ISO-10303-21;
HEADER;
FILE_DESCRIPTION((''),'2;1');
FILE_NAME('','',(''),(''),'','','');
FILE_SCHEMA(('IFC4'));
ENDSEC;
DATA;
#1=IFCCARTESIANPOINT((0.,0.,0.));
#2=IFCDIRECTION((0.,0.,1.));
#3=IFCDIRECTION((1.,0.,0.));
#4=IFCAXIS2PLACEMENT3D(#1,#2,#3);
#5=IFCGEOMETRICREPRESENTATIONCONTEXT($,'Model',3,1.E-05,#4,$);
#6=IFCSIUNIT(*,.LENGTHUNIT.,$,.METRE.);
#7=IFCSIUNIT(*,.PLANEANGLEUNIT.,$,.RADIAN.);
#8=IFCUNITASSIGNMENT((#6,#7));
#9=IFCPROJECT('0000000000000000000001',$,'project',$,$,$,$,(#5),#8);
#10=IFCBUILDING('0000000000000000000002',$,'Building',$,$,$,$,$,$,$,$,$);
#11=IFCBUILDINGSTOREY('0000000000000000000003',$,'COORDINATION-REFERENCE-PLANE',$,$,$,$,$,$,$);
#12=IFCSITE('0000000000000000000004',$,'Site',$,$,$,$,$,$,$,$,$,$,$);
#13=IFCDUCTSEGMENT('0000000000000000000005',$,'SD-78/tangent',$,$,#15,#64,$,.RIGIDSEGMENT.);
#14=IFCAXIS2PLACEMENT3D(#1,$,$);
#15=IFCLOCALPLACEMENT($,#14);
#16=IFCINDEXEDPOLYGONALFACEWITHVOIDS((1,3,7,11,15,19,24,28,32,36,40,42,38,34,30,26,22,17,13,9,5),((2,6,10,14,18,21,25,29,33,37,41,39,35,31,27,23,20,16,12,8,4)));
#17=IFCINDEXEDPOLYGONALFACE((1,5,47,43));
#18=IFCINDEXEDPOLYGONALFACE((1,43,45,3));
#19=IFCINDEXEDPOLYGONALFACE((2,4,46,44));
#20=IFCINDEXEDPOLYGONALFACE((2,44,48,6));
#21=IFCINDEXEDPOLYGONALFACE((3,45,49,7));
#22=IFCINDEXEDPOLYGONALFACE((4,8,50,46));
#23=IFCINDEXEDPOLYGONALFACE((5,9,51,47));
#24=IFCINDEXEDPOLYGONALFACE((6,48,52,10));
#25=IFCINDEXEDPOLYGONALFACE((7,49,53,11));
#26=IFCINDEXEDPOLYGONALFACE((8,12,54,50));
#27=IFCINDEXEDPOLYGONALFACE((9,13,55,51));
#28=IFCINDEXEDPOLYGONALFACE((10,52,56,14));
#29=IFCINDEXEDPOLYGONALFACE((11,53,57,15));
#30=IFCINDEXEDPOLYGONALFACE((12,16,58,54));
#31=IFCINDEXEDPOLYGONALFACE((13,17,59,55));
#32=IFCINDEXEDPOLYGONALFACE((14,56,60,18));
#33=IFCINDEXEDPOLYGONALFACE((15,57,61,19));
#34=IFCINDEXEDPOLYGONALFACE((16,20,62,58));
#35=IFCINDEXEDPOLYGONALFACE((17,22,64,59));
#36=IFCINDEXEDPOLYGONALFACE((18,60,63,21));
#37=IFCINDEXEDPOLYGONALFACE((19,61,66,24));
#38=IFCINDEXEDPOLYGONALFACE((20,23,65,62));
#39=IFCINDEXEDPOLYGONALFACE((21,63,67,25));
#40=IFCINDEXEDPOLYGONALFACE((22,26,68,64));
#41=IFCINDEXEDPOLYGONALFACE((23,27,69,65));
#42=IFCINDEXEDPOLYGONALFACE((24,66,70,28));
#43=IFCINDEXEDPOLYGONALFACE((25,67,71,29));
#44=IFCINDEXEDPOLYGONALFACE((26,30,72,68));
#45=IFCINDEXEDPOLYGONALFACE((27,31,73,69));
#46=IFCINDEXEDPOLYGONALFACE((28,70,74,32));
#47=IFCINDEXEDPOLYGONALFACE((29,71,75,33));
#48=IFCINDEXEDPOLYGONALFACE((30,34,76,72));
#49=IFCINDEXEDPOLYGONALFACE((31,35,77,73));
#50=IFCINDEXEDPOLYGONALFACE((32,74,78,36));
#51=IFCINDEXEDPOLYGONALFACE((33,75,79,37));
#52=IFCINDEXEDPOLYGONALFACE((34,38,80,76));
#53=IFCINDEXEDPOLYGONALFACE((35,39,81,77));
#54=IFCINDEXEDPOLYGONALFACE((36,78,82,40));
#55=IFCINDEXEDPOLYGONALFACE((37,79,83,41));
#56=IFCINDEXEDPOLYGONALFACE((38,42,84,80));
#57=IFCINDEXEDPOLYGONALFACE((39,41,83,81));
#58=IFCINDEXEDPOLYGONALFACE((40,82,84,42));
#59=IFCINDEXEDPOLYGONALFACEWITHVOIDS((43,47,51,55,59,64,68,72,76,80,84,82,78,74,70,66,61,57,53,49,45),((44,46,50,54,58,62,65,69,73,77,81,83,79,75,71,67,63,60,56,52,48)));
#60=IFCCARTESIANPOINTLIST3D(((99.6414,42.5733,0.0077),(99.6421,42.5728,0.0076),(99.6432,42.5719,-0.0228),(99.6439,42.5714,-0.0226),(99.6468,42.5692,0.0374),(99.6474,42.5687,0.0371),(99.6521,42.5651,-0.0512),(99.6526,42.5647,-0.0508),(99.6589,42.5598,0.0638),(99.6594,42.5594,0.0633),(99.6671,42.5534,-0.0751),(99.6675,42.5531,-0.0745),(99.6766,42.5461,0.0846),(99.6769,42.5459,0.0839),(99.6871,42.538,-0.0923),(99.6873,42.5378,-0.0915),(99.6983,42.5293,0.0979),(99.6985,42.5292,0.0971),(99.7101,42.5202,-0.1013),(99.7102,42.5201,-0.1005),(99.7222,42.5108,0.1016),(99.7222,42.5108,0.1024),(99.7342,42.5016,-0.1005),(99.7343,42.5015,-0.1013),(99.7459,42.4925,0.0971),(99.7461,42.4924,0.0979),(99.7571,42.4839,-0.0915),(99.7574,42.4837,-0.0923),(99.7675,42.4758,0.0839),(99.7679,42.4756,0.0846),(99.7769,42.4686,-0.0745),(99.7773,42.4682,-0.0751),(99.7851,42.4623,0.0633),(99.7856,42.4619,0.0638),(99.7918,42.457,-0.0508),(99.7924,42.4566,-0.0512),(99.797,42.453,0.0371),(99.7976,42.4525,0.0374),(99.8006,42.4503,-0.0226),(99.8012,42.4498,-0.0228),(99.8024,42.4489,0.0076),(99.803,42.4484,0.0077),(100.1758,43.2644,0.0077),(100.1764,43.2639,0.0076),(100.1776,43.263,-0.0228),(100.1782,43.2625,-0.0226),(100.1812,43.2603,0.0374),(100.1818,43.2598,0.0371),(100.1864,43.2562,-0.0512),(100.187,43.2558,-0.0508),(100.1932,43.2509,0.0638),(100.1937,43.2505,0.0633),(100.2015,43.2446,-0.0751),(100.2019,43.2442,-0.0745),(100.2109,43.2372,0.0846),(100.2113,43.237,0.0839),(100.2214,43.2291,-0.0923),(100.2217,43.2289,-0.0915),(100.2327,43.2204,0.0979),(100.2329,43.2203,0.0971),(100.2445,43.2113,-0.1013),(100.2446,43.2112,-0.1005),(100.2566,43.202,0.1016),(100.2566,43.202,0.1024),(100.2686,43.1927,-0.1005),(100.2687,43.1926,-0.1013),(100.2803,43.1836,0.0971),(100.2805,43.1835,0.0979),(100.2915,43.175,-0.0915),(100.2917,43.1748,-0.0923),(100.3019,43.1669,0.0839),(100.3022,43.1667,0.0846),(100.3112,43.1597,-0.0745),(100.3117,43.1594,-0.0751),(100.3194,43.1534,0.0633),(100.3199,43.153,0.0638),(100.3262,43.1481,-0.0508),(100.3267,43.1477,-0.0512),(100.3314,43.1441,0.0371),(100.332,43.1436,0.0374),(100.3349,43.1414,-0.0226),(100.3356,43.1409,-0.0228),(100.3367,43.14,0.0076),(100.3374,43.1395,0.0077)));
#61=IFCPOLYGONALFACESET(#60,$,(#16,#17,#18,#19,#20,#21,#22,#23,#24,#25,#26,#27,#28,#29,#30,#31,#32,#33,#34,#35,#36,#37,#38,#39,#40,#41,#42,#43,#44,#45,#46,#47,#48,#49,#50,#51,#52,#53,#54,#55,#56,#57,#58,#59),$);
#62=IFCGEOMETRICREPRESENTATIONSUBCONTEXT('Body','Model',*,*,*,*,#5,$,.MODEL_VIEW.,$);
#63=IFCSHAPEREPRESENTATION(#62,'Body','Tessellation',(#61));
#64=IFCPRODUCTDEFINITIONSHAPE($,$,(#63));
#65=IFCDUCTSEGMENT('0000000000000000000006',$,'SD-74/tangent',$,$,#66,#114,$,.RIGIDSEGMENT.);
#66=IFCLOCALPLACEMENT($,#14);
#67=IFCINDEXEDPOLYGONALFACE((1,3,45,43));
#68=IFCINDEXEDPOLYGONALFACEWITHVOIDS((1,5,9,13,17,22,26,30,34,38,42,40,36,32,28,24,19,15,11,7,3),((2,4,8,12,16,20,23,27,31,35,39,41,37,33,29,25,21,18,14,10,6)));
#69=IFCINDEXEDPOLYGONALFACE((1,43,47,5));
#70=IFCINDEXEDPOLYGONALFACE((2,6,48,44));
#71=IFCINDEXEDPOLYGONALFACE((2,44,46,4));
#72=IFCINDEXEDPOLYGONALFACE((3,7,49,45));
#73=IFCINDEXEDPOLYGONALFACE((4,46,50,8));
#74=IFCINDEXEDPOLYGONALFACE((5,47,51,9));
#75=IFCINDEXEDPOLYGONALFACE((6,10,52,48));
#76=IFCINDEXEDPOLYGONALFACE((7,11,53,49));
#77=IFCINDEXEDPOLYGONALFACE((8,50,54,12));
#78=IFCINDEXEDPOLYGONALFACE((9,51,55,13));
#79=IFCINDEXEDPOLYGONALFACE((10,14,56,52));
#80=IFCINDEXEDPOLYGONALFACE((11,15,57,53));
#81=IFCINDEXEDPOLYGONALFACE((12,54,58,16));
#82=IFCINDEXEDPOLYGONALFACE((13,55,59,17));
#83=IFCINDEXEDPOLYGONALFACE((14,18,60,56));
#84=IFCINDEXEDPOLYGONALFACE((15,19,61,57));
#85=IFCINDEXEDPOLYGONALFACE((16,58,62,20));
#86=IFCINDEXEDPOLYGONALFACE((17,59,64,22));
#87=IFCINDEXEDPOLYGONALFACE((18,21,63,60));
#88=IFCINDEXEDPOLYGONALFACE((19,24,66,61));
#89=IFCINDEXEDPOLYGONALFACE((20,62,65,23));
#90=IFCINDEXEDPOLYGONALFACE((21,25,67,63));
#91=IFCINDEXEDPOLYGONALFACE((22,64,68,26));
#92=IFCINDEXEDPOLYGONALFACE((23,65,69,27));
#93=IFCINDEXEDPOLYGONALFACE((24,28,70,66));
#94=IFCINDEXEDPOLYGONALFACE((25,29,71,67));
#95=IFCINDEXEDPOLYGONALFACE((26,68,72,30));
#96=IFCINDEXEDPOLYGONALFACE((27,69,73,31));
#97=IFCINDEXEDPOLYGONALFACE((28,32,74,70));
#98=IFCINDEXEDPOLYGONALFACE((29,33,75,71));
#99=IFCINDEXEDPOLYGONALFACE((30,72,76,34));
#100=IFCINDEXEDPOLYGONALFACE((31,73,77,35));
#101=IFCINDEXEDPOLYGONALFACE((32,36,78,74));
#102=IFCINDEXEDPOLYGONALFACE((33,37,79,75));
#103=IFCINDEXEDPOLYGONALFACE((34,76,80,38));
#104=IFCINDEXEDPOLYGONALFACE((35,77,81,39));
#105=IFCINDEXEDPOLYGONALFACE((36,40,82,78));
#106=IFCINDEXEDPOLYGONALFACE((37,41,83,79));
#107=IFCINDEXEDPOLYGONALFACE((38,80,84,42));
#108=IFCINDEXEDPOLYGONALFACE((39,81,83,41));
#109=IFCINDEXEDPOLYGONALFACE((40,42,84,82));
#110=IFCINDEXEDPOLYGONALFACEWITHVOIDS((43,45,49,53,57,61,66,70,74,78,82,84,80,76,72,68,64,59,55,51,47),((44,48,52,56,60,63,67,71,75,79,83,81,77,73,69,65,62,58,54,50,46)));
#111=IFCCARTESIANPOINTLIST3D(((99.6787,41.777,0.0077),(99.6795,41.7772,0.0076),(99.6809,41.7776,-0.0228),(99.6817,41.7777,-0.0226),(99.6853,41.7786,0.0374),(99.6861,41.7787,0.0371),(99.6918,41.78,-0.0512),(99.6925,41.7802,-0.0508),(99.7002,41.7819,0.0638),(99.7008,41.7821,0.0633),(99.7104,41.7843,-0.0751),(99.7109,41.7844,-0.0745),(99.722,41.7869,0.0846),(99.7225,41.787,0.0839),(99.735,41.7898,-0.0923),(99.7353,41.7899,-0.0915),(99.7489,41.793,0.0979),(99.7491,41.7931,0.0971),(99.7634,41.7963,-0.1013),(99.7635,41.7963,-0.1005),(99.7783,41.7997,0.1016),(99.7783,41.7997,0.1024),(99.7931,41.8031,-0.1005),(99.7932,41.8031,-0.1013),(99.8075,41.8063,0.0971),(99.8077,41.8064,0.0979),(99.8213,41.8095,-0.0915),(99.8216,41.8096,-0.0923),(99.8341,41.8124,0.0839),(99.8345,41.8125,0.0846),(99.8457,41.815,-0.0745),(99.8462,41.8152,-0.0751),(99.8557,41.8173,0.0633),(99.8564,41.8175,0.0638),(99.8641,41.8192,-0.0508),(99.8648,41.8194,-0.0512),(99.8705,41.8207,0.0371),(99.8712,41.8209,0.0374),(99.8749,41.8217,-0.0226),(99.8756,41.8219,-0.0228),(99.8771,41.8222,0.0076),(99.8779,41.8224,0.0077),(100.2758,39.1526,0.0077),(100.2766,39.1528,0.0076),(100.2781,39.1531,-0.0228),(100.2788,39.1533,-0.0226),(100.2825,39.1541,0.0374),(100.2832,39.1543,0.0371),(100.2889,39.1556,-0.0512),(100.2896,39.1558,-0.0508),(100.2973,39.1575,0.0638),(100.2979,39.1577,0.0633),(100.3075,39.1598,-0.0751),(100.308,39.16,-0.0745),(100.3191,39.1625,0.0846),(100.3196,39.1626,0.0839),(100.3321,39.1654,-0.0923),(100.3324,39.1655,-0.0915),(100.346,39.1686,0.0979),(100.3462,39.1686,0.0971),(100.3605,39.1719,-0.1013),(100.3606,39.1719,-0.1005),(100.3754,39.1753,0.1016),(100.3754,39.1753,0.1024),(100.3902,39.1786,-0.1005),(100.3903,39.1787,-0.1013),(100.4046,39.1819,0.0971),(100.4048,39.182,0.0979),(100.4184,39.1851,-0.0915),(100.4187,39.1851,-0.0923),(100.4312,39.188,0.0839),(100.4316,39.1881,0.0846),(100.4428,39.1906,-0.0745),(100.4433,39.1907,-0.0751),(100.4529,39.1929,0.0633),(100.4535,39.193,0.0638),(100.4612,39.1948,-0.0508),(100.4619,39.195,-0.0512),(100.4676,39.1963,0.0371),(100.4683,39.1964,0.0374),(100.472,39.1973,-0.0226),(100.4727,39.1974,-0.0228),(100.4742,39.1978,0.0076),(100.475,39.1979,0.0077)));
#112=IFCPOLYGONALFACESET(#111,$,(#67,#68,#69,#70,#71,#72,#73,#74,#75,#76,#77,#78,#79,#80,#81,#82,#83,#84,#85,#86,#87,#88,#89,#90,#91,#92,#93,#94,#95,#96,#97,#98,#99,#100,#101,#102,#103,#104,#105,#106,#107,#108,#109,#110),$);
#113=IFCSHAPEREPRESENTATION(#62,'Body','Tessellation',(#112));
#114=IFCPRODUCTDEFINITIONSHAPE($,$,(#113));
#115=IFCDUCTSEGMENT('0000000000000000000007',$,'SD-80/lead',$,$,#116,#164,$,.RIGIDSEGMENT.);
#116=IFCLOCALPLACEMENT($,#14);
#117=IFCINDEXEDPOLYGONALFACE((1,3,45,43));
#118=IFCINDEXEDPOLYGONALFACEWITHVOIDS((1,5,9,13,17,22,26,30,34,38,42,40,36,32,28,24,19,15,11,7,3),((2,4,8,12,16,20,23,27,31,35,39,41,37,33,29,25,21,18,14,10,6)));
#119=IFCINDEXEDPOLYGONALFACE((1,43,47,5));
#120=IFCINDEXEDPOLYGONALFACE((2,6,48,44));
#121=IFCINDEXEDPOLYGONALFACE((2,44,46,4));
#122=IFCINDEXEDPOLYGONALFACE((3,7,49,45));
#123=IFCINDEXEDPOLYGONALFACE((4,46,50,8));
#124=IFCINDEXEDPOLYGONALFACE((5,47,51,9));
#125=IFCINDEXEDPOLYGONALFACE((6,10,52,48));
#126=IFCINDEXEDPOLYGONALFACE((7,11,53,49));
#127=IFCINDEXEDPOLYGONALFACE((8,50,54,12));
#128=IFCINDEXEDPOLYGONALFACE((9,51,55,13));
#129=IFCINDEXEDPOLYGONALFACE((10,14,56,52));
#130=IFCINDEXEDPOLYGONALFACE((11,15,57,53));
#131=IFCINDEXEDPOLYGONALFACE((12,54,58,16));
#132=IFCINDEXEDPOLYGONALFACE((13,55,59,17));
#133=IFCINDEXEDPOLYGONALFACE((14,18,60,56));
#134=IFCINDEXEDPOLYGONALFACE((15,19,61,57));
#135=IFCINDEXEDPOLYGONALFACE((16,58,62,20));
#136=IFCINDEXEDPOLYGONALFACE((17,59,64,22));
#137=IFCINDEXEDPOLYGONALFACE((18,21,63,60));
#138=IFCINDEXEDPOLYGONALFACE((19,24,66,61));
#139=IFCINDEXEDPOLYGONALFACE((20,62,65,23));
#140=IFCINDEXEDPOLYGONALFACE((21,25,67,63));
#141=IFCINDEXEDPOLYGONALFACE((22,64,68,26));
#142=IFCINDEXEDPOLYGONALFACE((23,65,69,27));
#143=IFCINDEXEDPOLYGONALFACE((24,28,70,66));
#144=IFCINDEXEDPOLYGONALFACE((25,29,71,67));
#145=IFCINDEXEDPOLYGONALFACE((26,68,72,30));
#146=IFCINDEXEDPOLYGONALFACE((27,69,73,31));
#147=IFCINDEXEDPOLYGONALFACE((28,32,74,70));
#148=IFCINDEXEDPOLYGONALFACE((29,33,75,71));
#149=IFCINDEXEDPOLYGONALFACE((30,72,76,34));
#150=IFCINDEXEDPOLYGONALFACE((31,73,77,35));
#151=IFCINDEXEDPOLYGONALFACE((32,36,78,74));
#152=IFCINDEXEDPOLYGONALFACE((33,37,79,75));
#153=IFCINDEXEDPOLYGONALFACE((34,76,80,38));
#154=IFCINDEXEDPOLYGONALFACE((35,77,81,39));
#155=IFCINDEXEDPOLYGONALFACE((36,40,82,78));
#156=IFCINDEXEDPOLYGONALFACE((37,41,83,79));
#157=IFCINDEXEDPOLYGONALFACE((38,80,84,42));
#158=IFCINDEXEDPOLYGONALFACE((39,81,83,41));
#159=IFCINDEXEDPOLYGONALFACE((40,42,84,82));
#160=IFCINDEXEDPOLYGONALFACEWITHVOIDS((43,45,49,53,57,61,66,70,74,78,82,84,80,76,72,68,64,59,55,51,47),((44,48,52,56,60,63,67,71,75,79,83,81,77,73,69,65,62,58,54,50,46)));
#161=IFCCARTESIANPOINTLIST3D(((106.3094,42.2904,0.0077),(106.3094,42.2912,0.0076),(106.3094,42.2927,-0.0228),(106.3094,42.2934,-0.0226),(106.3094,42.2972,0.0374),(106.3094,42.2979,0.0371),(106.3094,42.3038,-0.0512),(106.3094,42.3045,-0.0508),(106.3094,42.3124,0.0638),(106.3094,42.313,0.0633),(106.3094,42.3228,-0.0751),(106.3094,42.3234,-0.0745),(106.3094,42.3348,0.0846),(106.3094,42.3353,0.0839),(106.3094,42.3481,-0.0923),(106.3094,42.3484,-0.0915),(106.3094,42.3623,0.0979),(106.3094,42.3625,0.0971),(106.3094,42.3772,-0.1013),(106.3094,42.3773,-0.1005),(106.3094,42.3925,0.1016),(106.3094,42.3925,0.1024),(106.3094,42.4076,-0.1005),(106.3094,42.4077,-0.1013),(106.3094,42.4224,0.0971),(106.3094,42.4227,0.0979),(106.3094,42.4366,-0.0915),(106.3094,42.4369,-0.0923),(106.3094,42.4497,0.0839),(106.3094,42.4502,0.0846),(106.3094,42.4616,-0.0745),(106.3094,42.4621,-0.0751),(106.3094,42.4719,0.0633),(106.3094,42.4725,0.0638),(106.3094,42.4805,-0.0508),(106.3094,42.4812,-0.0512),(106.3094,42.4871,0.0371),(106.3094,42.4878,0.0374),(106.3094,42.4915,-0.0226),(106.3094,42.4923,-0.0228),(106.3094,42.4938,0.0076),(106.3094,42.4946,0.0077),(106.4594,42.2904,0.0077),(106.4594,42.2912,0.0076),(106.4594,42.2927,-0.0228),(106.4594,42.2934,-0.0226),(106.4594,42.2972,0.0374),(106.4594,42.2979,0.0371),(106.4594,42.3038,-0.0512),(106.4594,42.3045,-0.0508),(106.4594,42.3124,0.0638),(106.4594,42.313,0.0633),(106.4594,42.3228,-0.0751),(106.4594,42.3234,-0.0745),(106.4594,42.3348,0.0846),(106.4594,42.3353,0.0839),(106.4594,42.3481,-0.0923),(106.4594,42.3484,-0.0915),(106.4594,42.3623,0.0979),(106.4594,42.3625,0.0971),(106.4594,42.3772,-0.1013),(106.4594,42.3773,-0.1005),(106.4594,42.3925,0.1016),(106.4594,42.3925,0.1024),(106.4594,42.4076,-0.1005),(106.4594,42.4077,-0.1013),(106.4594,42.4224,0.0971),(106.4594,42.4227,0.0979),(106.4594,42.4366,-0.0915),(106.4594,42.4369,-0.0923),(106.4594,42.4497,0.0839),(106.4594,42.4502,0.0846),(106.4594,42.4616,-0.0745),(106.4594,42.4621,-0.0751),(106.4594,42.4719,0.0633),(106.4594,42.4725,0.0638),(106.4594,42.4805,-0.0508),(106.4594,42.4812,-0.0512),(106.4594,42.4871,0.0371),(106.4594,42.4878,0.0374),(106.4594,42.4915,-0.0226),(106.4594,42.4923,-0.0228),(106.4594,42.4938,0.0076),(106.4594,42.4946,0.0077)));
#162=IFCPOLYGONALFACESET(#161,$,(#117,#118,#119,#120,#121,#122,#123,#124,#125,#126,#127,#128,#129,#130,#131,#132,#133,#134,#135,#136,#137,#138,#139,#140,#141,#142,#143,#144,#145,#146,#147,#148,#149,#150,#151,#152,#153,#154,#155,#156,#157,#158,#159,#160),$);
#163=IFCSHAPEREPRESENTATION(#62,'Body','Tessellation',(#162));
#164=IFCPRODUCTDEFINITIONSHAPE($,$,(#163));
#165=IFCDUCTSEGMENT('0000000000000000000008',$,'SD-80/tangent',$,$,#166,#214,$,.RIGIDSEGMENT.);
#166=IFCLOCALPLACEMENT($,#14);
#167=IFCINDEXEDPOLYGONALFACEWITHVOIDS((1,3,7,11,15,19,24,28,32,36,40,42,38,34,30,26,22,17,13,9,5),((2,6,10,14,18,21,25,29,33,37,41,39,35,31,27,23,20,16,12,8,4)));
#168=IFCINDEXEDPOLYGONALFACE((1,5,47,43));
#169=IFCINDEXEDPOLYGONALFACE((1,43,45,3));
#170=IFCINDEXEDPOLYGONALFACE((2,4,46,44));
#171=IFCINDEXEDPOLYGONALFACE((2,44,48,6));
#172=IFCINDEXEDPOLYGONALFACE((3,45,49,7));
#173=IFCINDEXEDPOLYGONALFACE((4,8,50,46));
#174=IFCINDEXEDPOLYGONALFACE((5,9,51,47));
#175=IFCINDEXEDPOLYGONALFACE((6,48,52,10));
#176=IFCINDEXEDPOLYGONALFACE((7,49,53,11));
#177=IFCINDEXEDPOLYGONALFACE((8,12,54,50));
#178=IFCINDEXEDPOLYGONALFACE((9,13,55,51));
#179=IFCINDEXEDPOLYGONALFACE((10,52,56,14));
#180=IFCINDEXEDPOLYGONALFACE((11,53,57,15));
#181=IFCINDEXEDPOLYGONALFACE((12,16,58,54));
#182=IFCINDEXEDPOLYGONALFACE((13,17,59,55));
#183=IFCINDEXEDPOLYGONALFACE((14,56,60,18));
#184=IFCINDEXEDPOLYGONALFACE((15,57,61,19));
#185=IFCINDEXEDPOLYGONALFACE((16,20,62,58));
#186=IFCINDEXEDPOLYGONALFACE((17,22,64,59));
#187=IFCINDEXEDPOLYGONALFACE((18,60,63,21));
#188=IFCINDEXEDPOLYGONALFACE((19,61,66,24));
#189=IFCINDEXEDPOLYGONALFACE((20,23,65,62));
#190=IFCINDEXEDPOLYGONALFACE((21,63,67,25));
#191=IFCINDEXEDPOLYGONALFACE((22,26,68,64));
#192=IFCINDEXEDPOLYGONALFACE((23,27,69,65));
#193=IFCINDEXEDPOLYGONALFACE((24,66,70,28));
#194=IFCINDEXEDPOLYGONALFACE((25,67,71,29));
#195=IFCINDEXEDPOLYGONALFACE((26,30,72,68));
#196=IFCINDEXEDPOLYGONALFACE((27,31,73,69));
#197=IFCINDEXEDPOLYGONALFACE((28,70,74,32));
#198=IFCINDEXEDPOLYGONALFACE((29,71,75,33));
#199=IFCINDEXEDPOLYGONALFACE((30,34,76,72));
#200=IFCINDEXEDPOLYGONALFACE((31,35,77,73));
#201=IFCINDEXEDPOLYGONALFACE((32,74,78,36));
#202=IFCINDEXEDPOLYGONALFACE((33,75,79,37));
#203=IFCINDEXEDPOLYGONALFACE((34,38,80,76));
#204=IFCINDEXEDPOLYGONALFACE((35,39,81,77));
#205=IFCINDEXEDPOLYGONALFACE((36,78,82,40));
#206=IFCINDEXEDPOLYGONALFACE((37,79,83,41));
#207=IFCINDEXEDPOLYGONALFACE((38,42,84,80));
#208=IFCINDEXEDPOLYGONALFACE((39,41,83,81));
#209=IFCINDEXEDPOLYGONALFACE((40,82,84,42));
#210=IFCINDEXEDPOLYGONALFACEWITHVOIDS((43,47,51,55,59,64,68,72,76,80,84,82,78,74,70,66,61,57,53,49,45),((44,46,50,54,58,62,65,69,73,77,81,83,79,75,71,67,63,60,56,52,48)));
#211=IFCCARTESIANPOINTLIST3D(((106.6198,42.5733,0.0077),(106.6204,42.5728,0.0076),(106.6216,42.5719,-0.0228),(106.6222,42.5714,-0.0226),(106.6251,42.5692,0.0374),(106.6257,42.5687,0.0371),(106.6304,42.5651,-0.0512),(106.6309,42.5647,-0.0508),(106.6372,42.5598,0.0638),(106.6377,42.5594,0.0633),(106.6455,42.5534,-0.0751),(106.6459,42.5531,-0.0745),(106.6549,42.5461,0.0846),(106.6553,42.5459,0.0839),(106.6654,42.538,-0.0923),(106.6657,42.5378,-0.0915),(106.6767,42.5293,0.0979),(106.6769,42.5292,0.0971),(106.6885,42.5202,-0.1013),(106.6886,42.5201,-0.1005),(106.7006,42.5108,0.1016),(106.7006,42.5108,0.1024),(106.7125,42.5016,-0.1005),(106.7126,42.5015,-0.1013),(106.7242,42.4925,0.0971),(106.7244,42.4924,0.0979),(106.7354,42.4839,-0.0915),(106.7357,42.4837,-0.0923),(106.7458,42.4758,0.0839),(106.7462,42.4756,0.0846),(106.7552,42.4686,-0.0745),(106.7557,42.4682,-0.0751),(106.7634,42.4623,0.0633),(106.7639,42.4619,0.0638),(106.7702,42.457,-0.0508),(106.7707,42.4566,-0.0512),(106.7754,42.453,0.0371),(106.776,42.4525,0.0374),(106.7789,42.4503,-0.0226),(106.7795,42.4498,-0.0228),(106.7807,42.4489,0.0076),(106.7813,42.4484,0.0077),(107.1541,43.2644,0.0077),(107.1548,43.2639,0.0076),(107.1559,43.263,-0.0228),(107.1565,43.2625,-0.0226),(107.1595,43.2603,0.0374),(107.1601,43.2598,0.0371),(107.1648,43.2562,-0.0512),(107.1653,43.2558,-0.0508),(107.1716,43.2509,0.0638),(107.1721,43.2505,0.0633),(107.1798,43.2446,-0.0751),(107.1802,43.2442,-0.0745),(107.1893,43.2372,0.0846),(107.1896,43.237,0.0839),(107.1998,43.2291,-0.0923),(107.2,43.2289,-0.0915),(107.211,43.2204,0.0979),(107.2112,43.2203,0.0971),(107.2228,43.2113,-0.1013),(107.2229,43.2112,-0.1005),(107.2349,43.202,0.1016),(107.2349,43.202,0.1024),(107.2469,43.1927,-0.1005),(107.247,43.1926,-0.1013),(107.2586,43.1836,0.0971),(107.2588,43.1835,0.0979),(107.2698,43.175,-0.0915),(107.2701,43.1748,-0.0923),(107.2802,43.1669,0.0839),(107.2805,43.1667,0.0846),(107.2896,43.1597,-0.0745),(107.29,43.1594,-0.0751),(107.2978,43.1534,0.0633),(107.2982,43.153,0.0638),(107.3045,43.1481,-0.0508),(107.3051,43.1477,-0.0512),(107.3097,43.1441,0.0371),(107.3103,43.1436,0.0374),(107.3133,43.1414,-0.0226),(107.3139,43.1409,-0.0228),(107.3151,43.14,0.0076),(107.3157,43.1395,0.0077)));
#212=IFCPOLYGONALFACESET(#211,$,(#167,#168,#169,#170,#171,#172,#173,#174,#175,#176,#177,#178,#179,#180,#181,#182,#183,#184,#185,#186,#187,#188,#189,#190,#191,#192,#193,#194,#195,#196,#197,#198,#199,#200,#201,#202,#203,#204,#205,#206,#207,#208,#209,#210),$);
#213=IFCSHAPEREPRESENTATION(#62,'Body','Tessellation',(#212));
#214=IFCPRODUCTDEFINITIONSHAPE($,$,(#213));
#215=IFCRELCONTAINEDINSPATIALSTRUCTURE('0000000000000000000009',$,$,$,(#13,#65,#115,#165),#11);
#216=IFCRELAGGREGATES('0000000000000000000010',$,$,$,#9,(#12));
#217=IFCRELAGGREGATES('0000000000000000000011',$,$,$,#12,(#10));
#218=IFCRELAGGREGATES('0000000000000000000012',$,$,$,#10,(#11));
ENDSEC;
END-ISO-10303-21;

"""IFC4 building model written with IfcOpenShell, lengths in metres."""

from ifc_helpers import new_model, si_unit, frame, origin_with_axes, place, context, subcontext, project, spatial, hollow_circle, extrude, element, save


model = new_model("IFC4")

# Units and contexts
model_context = context("Model", 3, precision=1e-05, world=origin_with_axes())
body_context_1 = subcontext(model_context, "Body", "Model", "MODEL_VIEW")
ifc_project = project(units=[si_unit("LENGTHUNIT", "METRE"), si_unit("PLANEANGLEUNIT", "RADIAN")], contexts=[model_context])

# Site, building, storey
site = spatial("IfcSite", under=ifc_project, Name="Site")
building = spatial("IfcBuilding", under=site, Name="Building")
storey = spatial("IfcBuildingStorey", under=building, Name="COORDINATION-REFERENCE-PLANE")

# Duct segment
duct_segment_1_placement = place(None, frame((99.7222, 42.5108, 0.0), z_axis=(0.611676, 0.791108, 0.0), x_axis=(0.0, 0.0, 1.0)))
element("IfcDuctSegment", 1, at=duct_segment_1_placement, inside=storey, Name="SD-78/tangent", PredefinedType="RIGIDSEGMENT", context=body_context_1, shape_type="SweptSolid", body=[
    extrude(hollow_circle(Radius=0.1024, WallThickness=0.0008), origin_with_axes(), (0.0, 0.0, 1.0), 0.8736),
])

# Duct segment
duct_segment_2_placement = place(None, frame((99.7783, 41.7997, 0.0), z_axis=(0.221849, -0.975081, 0.0), x_axis=(0.0, 0.0, 1.0)))
element("IfcDuctSegment", 2, at=duct_segment_2_placement, inside=storey, Name="SD-74/tangent", PredefinedType="RIGIDSEGMENT", context=body_context_1, shape_type="SweptSolid", body=[
    extrude(hollow_circle(Radius=0.1024, WallThickness=0.0008), origin_with_axes(), (0.0, 0.0, 1.0), 2.6915),
])

# Duct segment
duct_segment_3_placement = place(None, frame((106.3094, 42.3925, 0.0), z_axis=(1.0, 0.0, 0.0), x_axis=(0.0, 0.0, 1.0)))
element("IfcDuctSegment", 3, at=duct_segment_3_placement, inside=storey, Name="SD-80/lead", PredefinedType="RIGIDSEGMENT", context=body_context_1, shape_type="SweptSolid", body=[
    extrude(hollow_circle(Radius=0.1024, WallThickness=0.0008), origin_with_axes(), (0.0, 0.0, 1.0), 0.15),
])

# Duct segment
duct_segment_4_placement = place(None, frame((106.7006, 42.5108, 0.0), z_axis=(0.611676, 0.791108, 0.0), x_axis=(0.0, 0.0, 1.0)))
element("IfcDuctSegment", 4, at=duct_segment_4_placement, inside=storey, Name="SD-80/tangent", PredefinedType="RIGIDSEGMENT", context=body_context_1, shape_type="SweptSolid", body=[
    extrude(hollow_circle(Radius=0.1024, WallThickness=0.0008), origin_with_axes(), (0.0, 0.0, 1.0), 0.8736),
])

save(model, "model.ifc")
